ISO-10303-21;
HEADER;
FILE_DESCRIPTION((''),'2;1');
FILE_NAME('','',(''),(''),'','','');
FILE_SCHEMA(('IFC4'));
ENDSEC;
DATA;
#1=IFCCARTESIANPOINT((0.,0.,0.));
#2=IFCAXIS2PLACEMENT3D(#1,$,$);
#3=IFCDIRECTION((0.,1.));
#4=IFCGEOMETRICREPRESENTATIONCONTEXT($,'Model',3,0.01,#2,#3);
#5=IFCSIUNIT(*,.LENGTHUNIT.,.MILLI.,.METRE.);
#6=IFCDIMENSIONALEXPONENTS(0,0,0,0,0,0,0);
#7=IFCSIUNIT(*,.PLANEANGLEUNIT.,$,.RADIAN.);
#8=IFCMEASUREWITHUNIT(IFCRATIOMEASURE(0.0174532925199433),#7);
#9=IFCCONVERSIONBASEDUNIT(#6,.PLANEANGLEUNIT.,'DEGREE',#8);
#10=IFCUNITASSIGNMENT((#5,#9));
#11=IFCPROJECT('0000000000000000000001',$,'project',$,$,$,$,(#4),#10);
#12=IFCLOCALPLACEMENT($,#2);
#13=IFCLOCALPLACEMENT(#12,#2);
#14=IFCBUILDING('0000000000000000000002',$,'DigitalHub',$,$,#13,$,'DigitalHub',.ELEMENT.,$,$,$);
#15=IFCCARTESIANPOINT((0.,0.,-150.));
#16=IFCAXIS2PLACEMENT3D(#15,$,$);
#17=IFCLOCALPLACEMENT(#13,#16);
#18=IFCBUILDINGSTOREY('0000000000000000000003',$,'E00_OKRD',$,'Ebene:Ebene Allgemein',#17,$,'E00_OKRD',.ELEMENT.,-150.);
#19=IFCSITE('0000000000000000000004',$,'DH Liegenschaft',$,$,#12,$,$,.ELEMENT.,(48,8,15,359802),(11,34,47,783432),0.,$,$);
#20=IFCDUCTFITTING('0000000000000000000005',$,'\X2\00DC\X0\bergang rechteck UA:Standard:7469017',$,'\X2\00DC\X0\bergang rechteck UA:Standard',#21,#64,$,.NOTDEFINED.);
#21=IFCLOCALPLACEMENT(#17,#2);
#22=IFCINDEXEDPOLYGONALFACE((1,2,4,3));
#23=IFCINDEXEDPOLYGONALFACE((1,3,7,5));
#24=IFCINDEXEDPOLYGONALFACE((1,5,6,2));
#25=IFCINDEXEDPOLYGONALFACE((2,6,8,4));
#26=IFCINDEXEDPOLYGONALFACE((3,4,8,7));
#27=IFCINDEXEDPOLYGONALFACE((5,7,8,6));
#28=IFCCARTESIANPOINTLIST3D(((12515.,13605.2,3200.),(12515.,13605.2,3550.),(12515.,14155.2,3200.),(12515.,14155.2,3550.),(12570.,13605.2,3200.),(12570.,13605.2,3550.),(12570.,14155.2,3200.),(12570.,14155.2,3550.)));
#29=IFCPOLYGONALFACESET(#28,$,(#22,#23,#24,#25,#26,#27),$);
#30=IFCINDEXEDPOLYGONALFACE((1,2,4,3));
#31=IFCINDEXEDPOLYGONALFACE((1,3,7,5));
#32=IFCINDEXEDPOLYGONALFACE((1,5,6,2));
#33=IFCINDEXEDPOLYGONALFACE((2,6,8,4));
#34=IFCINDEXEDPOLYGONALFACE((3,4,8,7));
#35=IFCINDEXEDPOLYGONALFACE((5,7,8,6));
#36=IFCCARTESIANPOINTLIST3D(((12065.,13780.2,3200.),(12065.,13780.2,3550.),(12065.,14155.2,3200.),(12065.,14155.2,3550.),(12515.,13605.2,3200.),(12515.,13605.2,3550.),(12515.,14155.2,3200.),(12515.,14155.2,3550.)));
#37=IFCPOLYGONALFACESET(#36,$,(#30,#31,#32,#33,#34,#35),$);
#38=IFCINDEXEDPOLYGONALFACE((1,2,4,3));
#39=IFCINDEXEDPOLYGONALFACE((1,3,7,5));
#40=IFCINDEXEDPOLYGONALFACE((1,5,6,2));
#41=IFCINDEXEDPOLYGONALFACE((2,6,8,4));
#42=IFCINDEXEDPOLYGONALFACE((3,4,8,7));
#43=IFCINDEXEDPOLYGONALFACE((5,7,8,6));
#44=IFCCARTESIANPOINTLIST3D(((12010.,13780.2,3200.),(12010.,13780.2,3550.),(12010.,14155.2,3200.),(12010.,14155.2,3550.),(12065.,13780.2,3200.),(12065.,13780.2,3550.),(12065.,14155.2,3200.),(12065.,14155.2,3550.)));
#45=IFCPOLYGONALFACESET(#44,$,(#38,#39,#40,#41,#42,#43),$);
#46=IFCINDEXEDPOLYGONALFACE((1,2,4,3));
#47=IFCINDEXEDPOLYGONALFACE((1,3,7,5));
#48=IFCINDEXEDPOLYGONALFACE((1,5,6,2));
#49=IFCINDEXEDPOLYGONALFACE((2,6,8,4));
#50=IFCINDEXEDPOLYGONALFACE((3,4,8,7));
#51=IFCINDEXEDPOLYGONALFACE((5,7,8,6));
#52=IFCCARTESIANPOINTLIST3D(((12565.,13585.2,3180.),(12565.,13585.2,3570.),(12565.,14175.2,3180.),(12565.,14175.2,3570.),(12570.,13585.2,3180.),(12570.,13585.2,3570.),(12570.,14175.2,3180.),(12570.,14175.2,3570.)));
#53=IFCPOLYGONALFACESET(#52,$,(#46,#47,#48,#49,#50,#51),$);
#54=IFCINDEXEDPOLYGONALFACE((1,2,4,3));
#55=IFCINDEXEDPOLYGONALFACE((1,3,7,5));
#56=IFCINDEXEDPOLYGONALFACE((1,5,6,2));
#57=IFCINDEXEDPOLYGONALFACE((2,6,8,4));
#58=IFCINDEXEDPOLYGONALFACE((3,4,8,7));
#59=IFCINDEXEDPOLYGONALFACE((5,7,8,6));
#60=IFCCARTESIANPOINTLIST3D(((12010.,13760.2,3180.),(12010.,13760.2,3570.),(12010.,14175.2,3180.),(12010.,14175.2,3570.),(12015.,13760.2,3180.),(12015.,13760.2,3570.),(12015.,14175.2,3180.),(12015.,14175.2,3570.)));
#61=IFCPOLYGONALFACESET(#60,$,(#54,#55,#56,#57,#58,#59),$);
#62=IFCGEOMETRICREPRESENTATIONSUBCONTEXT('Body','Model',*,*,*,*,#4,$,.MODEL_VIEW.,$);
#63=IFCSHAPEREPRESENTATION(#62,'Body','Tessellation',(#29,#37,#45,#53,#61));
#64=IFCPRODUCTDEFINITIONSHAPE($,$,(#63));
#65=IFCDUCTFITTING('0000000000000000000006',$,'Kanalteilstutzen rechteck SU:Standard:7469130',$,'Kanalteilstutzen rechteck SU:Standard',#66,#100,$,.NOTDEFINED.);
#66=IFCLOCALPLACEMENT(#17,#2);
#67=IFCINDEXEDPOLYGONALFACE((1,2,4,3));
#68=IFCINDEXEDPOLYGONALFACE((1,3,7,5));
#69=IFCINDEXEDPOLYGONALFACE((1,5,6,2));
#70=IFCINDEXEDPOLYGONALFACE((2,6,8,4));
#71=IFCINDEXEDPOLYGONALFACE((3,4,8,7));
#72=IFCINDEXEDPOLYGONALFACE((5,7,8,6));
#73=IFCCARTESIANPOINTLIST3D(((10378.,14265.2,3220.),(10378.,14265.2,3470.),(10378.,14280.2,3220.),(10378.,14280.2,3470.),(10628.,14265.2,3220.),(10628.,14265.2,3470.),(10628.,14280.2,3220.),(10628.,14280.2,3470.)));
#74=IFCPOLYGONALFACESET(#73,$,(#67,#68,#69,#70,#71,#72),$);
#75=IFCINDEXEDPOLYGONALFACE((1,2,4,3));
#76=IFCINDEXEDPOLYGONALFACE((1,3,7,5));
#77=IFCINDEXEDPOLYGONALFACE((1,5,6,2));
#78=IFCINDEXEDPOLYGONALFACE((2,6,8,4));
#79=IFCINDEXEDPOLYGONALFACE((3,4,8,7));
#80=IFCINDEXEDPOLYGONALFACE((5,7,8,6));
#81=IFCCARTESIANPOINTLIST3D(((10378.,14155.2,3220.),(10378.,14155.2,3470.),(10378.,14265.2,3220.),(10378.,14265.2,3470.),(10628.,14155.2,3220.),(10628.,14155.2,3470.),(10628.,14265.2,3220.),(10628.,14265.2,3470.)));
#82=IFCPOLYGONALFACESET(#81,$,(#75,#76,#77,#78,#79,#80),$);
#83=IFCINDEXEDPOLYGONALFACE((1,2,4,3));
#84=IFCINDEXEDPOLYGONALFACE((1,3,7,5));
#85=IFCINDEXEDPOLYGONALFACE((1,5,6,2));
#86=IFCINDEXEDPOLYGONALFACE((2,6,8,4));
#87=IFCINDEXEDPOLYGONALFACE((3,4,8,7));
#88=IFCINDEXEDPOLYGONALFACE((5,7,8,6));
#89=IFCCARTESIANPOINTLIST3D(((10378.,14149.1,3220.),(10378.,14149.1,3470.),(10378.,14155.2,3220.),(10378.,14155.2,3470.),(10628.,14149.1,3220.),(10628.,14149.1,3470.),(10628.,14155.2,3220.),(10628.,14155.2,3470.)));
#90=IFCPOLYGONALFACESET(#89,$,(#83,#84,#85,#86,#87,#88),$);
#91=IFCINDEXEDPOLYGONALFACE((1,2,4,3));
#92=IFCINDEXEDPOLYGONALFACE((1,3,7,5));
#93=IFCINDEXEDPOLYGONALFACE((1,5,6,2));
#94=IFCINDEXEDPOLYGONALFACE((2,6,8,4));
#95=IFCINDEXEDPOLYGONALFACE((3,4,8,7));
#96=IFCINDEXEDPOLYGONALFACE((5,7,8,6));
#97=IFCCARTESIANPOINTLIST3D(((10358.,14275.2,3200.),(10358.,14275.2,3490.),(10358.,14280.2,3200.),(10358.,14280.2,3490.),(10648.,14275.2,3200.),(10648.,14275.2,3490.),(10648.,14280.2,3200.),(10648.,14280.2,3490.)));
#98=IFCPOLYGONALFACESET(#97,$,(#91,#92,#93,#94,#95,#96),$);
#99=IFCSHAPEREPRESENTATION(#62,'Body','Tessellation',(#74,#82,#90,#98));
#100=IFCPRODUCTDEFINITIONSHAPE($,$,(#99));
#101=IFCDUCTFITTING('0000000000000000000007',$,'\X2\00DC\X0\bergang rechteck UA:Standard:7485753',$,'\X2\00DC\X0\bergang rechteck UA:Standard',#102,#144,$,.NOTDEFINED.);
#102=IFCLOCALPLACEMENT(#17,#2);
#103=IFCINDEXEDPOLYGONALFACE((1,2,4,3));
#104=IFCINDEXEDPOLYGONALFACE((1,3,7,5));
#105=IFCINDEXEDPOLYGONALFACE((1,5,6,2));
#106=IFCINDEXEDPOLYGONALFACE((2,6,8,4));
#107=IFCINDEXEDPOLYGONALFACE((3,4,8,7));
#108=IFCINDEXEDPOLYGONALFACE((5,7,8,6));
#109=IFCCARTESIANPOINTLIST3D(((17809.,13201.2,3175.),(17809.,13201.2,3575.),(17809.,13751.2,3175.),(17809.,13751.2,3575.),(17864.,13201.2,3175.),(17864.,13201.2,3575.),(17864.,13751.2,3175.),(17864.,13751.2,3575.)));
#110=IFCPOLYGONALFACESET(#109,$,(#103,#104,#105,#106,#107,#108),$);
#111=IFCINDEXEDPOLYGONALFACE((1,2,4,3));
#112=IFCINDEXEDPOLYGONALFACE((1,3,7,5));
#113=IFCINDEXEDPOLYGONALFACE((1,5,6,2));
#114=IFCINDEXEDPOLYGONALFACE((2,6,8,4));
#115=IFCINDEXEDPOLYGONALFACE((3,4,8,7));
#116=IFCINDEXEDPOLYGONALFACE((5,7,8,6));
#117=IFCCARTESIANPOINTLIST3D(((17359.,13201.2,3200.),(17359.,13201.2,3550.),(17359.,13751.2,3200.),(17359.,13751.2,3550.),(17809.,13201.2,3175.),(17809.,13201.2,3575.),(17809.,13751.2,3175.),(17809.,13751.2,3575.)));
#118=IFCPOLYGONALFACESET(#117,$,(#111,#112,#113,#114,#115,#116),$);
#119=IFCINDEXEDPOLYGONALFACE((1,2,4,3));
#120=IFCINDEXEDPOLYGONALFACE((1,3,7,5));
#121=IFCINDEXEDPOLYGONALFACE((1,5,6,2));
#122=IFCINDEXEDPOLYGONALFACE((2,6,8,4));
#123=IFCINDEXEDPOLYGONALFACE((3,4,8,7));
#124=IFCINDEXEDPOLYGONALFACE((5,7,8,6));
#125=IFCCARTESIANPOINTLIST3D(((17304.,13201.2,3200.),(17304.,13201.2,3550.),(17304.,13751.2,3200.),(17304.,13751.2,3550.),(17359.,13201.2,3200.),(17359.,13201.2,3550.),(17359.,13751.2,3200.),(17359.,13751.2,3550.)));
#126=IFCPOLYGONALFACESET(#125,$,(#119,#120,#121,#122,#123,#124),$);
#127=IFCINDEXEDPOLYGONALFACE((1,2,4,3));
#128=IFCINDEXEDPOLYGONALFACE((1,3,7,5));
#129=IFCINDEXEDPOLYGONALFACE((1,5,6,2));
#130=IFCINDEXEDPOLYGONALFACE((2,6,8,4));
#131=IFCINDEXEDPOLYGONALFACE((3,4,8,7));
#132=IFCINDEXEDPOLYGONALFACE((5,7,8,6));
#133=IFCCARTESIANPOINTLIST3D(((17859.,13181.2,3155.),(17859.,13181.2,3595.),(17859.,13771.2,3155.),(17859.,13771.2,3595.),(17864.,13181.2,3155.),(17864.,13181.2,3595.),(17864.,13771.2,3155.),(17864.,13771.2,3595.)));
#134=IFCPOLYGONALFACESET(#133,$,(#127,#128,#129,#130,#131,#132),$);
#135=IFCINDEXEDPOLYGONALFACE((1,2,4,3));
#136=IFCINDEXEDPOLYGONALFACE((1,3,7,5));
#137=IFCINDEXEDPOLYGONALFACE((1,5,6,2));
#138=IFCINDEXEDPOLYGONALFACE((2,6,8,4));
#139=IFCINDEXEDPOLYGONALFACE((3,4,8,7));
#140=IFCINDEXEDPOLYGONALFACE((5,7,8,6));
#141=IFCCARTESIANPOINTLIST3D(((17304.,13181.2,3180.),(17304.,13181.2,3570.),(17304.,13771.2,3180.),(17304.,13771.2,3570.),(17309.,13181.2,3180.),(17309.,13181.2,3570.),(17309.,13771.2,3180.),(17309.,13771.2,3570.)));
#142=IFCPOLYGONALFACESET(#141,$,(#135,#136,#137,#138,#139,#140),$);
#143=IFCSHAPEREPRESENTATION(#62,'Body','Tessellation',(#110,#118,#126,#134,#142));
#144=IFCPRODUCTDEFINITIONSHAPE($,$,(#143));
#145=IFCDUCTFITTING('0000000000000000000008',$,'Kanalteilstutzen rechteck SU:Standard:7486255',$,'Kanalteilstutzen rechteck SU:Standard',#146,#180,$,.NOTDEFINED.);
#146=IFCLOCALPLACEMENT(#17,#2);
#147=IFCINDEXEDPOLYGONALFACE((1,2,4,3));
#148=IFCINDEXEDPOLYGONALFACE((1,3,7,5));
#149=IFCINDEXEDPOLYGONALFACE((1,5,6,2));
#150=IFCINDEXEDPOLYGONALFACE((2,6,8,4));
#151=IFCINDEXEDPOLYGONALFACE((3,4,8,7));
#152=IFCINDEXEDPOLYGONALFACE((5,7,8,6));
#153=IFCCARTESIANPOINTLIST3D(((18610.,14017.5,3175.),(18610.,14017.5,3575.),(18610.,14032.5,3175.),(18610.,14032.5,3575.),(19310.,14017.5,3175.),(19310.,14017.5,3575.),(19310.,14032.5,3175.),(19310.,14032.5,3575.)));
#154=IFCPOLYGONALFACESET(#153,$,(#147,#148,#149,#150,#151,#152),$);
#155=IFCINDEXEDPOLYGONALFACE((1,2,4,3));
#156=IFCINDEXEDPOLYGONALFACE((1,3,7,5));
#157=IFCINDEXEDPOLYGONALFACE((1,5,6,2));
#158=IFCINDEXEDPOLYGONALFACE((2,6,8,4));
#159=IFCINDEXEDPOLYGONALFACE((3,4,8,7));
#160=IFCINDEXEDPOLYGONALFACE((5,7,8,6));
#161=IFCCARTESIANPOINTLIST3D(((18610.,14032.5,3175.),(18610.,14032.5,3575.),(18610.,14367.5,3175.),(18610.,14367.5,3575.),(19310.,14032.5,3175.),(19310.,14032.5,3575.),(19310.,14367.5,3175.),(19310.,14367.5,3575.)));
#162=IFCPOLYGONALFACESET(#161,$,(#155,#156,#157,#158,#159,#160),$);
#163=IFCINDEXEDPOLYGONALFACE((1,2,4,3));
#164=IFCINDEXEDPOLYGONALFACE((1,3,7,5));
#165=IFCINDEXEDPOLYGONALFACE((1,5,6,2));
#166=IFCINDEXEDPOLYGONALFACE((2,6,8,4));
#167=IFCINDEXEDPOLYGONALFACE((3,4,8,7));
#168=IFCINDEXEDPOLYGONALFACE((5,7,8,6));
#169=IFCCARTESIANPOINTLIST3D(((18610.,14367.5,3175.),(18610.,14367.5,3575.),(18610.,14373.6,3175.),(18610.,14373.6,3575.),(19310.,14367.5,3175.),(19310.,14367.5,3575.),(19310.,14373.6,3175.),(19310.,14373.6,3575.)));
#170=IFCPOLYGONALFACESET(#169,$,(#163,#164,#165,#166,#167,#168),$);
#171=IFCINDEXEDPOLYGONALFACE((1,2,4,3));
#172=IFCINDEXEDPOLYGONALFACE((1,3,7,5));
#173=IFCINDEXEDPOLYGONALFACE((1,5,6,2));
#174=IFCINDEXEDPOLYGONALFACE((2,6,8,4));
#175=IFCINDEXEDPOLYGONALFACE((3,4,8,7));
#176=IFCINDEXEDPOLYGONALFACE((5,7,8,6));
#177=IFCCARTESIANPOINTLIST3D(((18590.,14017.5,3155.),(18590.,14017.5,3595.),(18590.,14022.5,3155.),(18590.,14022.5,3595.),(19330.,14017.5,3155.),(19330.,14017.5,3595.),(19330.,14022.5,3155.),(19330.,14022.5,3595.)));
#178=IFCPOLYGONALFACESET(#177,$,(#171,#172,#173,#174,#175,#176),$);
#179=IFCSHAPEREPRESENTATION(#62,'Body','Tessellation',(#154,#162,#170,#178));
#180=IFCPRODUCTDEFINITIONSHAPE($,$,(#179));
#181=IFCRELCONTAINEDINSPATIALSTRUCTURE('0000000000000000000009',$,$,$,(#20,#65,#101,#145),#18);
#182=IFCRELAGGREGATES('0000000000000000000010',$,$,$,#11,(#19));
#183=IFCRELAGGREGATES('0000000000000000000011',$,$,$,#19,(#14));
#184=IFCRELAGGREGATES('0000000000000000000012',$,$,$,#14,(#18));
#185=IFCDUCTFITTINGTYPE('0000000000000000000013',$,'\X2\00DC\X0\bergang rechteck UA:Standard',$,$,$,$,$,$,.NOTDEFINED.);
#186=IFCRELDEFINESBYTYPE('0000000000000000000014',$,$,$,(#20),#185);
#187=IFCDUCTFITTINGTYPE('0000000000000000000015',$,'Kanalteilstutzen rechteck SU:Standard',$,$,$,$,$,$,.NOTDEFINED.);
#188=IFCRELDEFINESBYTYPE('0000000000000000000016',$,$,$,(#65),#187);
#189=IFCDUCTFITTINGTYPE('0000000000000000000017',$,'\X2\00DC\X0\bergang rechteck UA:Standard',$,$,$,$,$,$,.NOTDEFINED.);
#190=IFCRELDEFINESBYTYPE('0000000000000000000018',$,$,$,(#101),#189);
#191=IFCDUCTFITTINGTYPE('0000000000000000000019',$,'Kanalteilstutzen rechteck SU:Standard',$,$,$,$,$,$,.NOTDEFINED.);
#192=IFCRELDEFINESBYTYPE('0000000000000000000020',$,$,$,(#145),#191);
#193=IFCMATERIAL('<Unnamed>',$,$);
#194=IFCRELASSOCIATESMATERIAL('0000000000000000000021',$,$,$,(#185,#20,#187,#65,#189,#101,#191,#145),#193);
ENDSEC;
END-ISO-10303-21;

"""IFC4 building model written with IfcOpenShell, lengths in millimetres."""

from ifc_helpers import new_model, entity, si_unit, converted_unit, direction, frame, origin, place, context, subcontext, project, spatial, indexed_curve, outline, extrude, source, transform, mapped, material, type_object, type_shapes, element, save


model = new_model("IFC4")

# Units and contexts
model_context = context("Model", 3, precision=0.01, world=origin(), true_north=direction((0.0, 1.0)))
body_context = subcontext(model_context, "Body", "Model", "MODEL_VIEW")
ifc_project = project(units=[si_unit("LENGTHUNIT", "METRE", prefix="MILLI"), converted_unit("PLANEANGLEUNIT", "DEGREE", entity("IfcRatioMeasure", 0.0174532925199433), si_unit("PLANEANGLEUNIT", "RADIAN"), dimensions=[0, 0, 0, 0, 0, 0, 0])], contexts=[model_context])

# Site, building, storey
site_placement = place(None, origin())
site = spatial("IfcSite", under=ifc_project, at=site_placement, Name="DH Liegenschaft", CompositionType="ELEMENT", RefLatitude=(48, 8, 15, 359802), RefLongitude=(11, 34, 47, 783432), RefElevation=0.0)
building_placement = place(site_placement, origin())
building = spatial("IfcBuilding", under=site, at=building_placement, Name="DigitalHub", LongName="DigitalHub", CompositionType="ELEMENT")
storey_placement = place(building_placement, frame((0.0, 0.0, -150.0)))
storey = spatial("IfcBuildingStorey", under=building, at=storey_placement, Name="E00_OKRD", ObjectType="Ebene:Ebene Allgemein", LongName="E00_OKRD", CompositionType="ELEMENT", Elevation=-150.0)

# Shared definitions
ifc_material_1 = material(Name="<Unnamed>")

# Duct fittings
duct_fitting_type_1 = type_object("IfcDuctFittingType", Name="Übergang rechteck UA:Standard", PredefinedType="NOTDEFINED", material=ifc_material_1)
shared_shape_1 = source(origin(), body_context, "Body", "SweptSolid", [
    extrude(outline(indexed_curve([(-27.5, -275.0), (27.5, -275.0), (27.5, 275.0), (-27.5, 275.0), (-27.5, -275.0)], self_intersect=False)), frame((532.5, -87.5, -175.0)), (0.0, 0.0, 1.0), 350.0),
    extrude(outline(indexed_curve([(-157.6, -215.5), (325.2, -215.5), (125.9, 297.1), (-293.5, 134.0), (-157.6, -215.5)], self_intersect=False)), frame((280.0, -43.7, -175.0), z_axis=(0.0, 0.0, 1.0), x_axis=(0.932005, -0.362446, 0.0)), (0.0, 0.0, 1.0), 350.0),
    extrude(outline(indexed_curve([(-27.5, -187.5), (27.5, -187.5), (27.5, 187.5), (-27.5, 187.5), (-27.5, -187.5)], self_intersect=False)), frame((27.5, 0.0, -175.0)), (0.0, 0.0, 1.0), 350.0),
    extrude(outline(indexed_curve([(-2.5, -295.0), (2.5, -295.0), (2.5, 295.0), (-2.5, 295.0), (-2.5, -295.0)], self_intersect=False)), frame((557.5, -87.5, -195.0)), (0.0, 0.0, 1.0), 390.0),
    extrude(outline(indexed_curve([(-2.5, -207.5), (2.5, -207.5), (2.5, 207.5), (-2.5, 207.5), (-2.5, -207.5)], self_intersect=False)), frame((2.5, 0.0, -195.0)), (0.0, 0.0, 1.0), 390.0),
])
type_shapes(duct_fitting_type_1, [shared_shape_1])
duct_fitting_1_placement = place(storey_placement, frame((12010.0, 13967.7, 3375.0)))
element("IfcDuctFitting", 1, at=duct_fitting_1_placement, inside=storey, type_object=duct_fitting_type_1, material=ifc_material_1, Name="Übergang rechteck UA:Standard:7469017", ObjectType="Übergang rechteck UA:Standard", PredefinedType="NOTDEFINED", context=body_context, shape_type="MappedRepresentation", body=[
    mapped(shared_shape_1, transform((0.0, 0.0, 0.0), scale=1.0)),
])
duct_fitting_type_2 = type_object("IfcDuctFittingType", Name="Kanalteilstutzen rechteck SU:Standard", PredefinedType="NOTDEFINED", material=ifc_material_1)
shared_shape_2 = source(origin(), body_context, "Body", "SweptSolid", [
    extrude(outline(indexed_curve([(-125.0, -7.5), (125.0, -7.5), (125.0, 7.5), (-125.0, 7.5), (-125.0, -7.5)], self_intersect=False)), frame((117.5, 0.0, -125.0), z_axis=(0.0, 0.0, 1.0), x_axis=(0.0, -1.0, 0.0)), (0.0, 0.0, 1.0), 250.0),
    extrude(outline(indexed_curve([(-125.0, -55.0), (125.0, -55.0), (125.0, 55.0), (-125.0, 55.0), (-125.0, -55.0)], self_intersect=False)), frame((55.0, 0.0, -125.0), z_axis=(0.0, 0.0, 1.0), x_axis=(0.0, -1.0, 0.0)), (0.0, 0.0, 1.0), 250.0),
    extrude(outline(indexed_curve([(-125.0, -3.0), (125.0, -3.0), (125.0, 3.0), (-125.0, 3.0), (-125.0, -3.0)], self_intersect=False)), frame((-3.0, 0.0, -125.0), z_axis=(0.0, 0.0, 1.0), x_axis=(0.0, -1.0, 0.0)), (0.0, 0.0, 1.0), 250.0),
    extrude(outline(indexed_curve([(-145.0, -2.5), (145.0, -2.5), (145.0, 2.5), (-145.0, 2.5), (-145.0, -2.5)], self_intersect=False)), frame((122.5, 0.0, -145.0), z_axis=(0.0, 0.0, 1.0), x_axis=(0.0, -1.0, 0.0)), (0.0, 0.0, 1.0), 290.0),
])
type_shapes(duct_fitting_type_2, [shared_shape_2])
duct_fitting_2_placement = place(storey_placement, frame((10503.0, 14155.2, 3345.0), z_axis=(0.0, 0.0, -1.0), x_axis=(0.0, 1.0, 0.0)))
element("IfcDuctFitting", 2, at=duct_fitting_2_placement, inside=storey, type_object=duct_fitting_type_2, material=ifc_material_1, Name="Kanalteilstutzen rechteck SU:Standard:7469130", ObjectType="Kanalteilstutzen rechteck SU:Standard", PredefinedType="NOTDEFINED", context=body_context, shape_type="MappedRepresentation", body=[
    mapped(shared_shape_2, transform((0.0, 0.0, 0.0), scale=1.0)),
])
duct_fitting_type_3 = type_object("IfcDuctFittingType", Name="Übergang rechteck UA:Standard", PredefinedType="NOTDEFINED", material=ifc_material_1)
shared_shape_3 = source(origin(), body_context, "Body", "SweptSolid", [
    extrude(outline(indexed_curve([(-27.5, -275.0), (27.5, -275.0), (27.5, 275.0), (-27.5, 275.0), (-27.5, -275.0)], self_intersect=False)), frame((532.5, 0.0, -200.0)), (0.0, 0.0, 1.0), 400.0),
    extrude(outline(indexed_curve([(-214.9, -187.2), (235.7, -187.2), (213.6, 212.2), (-234.4, 162.2), (-214.9, -187.2)], self_intersect=False)), frame((280.0, -275.0, 0.0), z_axis=(0.0, 1.0, 0.0), x_axis=(0.99846, 0.0, 0.05547)), (0.0, 0.0, 1.0), 550.0),
    extrude(outline(indexed_curve([(-27.5, -275.0), (27.5, -275.0), (27.5, 275.0), (-27.5, 275.0), (-27.5, -275.0)], self_intersect=False)), frame((27.5, 0.0, -175.0)), (0.0, 0.0, 1.0), 350.0),
    extrude(outline(indexed_curve([(-2.5, -295.0), (2.5, -295.0), (2.5, 295.0), (-2.5, 295.0), (-2.5, -295.0)], self_intersect=False)), frame((557.5, 0.0, -220.0)), (0.0, 0.0, 1.0), 440.0),
    extrude(outline(indexed_curve([(-2.5, -295.0), (2.5, -295.0), (2.5, 295.0), (-2.5, 295.0), (-2.5, -295.0)], self_intersect=False)), frame((2.5, 0.0, -195.0)), (0.0, 0.0, 1.0), 390.0),
])
type_shapes(duct_fitting_type_3, [shared_shape_3])
duct_fitting_3_placement = place(storey_placement, frame((17304.0, 13476.2, 3375.0)))
element("IfcDuctFitting", 3, at=duct_fitting_3_placement, inside=storey, type_object=duct_fitting_type_3, material=ifc_material_1, Name="Übergang rechteck UA:Standard:7485753", ObjectType="Übergang rechteck UA:Standard", PredefinedType="NOTDEFINED", context=body_context, shape_type="MappedRepresentation", body=[
    mapped(shared_shape_3, transform((0.0, 0.0, 0.0), scale=1.0)),
])
duct_fitting_type_4 = type_object("IfcDuctFittingType", Name="Kanalteilstutzen rechteck SU:Standard", PredefinedType="NOTDEFINED", material=ifc_material_1)
shared_shape_4 = source(origin(), body_context, "Body", "SweptSolid", [
    extrude(outline(indexed_curve([(-7.5, -200.0), (7.5, -200.0), (7.5, 200.0), (-7.5, 200.0), (-7.5, -200.0)], self_intersect=False)), frame((342.5, 0.0, -350.0)), (0.0, 0.0, 1.0), 700.0),
    extrude(outline(indexed_curve([(-167.5, -200.0), (167.5, -200.0), (167.5, 200.0), (-167.5, 200.0), (-167.5, -200.0)], self_intersect=False)), frame((167.5, 0.0, -350.0)), (0.0, 0.0, 1.0), 700.0),
    extrude(outline(indexed_curve([(-3.0, -200.0), (3.0, -200.0), (3.0, 200.0), (-3.0, 200.0), (-3.0, -200.0)], self_intersect=False)), frame((-3.0, 0.0, -350.0)), (0.0, 0.0, 1.0), 700.0),
    extrude(outline(indexed_curve([(-2.5, -220.0), (2.5, -220.0), (2.5, 220.0), (-2.5, 220.0), (-2.5, -220.0)], self_intersect=False)), frame((347.5, 0.0, -370.0)), (0.0, 0.0, 1.0), 740.0),
])
type_shapes(duct_fitting_type_4, [shared_shape_4])
duct_fitting_4_placement = place(storey_placement, frame((18960.0, 14367.5, 3375.0), z_axis=(-1.0, 0.0, 0.0), x_axis=(0.0, -1.0, 0.0)))
element("IfcDuctFitting", 4, at=duct_fitting_4_placement, inside=storey, type_object=duct_fitting_type_4, material=ifc_material_1, Name="Kanalteilstutzen rechteck SU:Standard:7486255", ObjectType="Kanalteilstutzen rechteck SU:Standard", PredefinedType="NOTDEFINED", context=body_context, shape_type="MappedRepresentation", body=[
    mapped(shared_shape_4, transform((0.0, 0.0, 0.0), scale=1.0)),
])

save(model, "model.ifc")
